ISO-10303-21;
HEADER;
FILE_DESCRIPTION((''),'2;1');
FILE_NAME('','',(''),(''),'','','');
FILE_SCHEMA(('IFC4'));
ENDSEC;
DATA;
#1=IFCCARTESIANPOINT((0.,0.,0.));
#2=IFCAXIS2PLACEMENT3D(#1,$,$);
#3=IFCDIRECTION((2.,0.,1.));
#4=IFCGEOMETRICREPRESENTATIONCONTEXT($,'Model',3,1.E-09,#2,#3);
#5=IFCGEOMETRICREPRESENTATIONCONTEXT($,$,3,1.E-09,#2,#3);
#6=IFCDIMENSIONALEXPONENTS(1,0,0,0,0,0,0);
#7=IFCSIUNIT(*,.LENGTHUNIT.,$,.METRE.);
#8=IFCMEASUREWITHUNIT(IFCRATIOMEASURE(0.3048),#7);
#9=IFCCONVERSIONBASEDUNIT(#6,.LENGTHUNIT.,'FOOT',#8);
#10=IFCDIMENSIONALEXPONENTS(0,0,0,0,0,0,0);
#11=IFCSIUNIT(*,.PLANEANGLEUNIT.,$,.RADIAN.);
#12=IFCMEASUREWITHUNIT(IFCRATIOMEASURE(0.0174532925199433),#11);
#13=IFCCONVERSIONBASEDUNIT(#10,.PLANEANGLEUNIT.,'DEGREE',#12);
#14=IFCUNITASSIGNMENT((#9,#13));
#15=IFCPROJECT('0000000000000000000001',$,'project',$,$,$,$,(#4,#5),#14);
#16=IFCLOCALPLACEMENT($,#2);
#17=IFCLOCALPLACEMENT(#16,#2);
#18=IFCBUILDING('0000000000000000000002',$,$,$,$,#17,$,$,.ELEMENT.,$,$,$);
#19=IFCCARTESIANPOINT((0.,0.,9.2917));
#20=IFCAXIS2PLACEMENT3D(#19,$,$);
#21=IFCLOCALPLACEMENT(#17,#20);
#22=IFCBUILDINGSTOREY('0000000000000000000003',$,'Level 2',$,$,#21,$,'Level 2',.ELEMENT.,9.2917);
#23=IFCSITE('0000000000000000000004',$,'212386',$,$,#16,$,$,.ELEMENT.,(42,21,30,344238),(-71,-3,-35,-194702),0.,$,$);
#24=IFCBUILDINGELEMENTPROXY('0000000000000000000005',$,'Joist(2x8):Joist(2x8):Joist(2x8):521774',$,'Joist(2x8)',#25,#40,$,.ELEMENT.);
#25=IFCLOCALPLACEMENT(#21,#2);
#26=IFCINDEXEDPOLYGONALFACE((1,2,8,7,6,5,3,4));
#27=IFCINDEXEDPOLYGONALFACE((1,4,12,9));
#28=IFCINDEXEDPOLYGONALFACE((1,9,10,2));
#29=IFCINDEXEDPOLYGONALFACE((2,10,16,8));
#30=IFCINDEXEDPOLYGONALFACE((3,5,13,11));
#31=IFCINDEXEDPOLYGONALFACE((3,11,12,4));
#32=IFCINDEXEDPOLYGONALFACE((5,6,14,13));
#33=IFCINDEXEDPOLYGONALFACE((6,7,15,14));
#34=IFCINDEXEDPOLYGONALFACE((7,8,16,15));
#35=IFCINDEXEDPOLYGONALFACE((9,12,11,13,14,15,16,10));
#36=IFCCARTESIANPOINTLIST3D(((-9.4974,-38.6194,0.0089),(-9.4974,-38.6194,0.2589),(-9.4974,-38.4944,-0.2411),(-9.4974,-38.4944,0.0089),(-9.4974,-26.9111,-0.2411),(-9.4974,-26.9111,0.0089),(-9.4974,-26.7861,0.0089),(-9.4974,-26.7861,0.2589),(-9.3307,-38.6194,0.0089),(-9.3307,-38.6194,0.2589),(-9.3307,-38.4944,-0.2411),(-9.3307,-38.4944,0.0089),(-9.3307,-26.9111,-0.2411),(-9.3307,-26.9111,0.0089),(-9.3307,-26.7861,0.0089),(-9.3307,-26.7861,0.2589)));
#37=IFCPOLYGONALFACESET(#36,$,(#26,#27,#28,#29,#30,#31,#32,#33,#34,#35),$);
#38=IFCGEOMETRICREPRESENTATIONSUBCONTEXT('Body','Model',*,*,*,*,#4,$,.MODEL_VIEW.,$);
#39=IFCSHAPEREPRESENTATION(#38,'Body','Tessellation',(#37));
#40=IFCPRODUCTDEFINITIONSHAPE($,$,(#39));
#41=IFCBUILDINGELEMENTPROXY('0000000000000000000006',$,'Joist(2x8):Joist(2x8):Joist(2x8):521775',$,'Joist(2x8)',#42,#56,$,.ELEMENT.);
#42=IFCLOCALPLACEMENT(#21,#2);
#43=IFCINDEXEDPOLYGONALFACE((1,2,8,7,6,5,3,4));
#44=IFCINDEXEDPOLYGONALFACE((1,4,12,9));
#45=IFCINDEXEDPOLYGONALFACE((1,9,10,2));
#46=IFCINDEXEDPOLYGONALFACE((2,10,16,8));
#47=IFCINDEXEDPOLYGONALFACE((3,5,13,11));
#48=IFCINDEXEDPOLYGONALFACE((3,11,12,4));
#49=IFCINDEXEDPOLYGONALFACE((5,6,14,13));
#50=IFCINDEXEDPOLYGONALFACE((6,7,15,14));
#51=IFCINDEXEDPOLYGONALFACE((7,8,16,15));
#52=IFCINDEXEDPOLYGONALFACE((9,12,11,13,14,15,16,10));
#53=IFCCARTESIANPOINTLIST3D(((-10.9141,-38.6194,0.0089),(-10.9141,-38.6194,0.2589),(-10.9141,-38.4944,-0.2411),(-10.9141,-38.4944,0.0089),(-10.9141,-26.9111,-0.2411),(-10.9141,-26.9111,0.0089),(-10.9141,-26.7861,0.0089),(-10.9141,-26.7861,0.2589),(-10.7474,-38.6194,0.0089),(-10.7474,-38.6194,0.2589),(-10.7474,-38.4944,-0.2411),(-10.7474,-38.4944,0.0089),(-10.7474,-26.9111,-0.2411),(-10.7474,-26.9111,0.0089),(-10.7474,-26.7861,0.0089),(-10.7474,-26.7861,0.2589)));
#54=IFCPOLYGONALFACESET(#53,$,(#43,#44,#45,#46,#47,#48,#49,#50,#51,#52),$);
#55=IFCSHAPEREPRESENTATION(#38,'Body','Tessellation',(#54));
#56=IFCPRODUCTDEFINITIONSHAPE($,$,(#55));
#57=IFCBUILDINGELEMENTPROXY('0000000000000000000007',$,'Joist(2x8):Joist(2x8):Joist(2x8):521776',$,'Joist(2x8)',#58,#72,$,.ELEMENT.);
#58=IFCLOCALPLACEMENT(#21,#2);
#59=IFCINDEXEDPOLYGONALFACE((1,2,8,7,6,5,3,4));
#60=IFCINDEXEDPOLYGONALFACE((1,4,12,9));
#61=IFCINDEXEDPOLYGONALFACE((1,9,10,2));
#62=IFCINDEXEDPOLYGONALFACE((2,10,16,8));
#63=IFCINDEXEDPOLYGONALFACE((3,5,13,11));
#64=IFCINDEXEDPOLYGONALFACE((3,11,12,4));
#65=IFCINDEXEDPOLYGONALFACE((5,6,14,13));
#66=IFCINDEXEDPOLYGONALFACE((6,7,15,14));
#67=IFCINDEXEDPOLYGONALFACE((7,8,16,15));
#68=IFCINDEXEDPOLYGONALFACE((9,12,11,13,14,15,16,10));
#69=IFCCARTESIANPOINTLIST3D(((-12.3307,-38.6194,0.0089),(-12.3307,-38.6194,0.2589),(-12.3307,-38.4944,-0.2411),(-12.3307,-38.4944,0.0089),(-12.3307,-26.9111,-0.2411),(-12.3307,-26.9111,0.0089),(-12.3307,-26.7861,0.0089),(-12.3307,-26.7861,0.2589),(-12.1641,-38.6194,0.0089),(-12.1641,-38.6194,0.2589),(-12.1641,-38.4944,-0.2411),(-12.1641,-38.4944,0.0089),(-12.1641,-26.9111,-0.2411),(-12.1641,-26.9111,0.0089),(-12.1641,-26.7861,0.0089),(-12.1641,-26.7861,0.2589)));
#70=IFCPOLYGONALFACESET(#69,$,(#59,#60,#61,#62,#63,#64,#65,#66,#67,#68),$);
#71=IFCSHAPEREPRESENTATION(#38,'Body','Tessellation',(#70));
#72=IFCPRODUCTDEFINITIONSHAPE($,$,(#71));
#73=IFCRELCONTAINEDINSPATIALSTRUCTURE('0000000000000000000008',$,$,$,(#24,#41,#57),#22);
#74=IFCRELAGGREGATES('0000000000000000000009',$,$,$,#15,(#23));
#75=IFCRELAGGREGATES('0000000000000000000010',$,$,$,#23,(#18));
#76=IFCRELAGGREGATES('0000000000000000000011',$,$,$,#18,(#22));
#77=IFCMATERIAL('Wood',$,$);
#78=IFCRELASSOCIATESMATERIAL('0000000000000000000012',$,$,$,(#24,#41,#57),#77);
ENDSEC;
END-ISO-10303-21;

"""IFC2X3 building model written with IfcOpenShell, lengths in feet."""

from ifc_helpers import new_model, entity, si_unit, converted_unit, direction, frame, origin, place, context, subcontext, project, spatial, polyline, outline, extrude, source, transform, mapped, material, element, save


model = new_model("IFC2X3")

# Units and contexts
model_context = context("Model", 3, precision=1e-09, world=origin(), true_north=direction((2.0, 0.0, 1.0)))
context_of_model = context(None, 3, precision=1e-09, world=origin(), true_north=direction((2.0, 0.0, 1.0)))
body_context = subcontext(model_context, "Body", "Model", "MODEL_VIEW")
ifc_project = project(units=[converted_unit("LENGTHUNIT", "FOOT", entity("IfcRatioMeasure", 0.3048), si_unit("LENGTHUNIT", "METRE"), dimensions=[1, 0, 0, 0, 0, 0, 0]), converted_unit("PLANEANGLEUNIT", "DEGREE", entity("IfcRatioMeasure", 0.0174532925199433), si_unit("PLANEANGLEUNIT", "RADIAN"), dimensions=[0, 0, 0, 0, 0, 0, 0])], contexts=[model_context, context_of_model])

# Site, building, storey
site_placement = place(None, origin())
site = spatial("IfcSite", under=ifc_project, at=site_placement, Name="212386", CompositionType="ELEMENT", RefLatitude=(42, 21, 30, 344238), RefLongitude=(-71, -3, -35, -194702), RefElevation=0.0)
building_placement = place(site_placement, origin())
building = spatial("IfcBuilding", under=site, at=building_placement, CompositionType="ELEMENT")
storey_placement = place(building_placement, frame((0.0, 0.0, 9.2917)))
storey = spatial("IfcBuildingStorey", under=building, at=storey_placement, Name="Level 2", LongName="Level 2", CompositionType="ELEMENT", Elevation=9.2917)

# Building element proxies
ifc_material = material(Name="Wood")
shared_shape_1 = source(origin(), body_context, "Body", "SweptSolid", [
    extrude(outline(polyline([(-0.25, -5.9167), (0.0, -5.9167), (0.0, -5.7917), (0.25, -5.7917), (0.25, 5.7917), (0.0, 5.7917), (0.0, 5.9167), (-0.25, 5.9167), (-0.25, -5.9167)])), frame((-9.4974, -32.7027, 9.3006), z_axis=(1.0, 0.0, 0.0), x_axis=(0.0, 0.0, -1.0)), (0.0, 0.0, 1.0), 0.1667),
])
proxy_1_placement = place(storey_placement, frame((0.0, 0.0, -9.2917)))
element("IfcBuildingElementProxy", 1, at=proxy_1_placement, inside=storey, material=ifc_material, Name="Joist(2x8):Joist(2x8):Joist(2x8):521774", ObjectType="Joist(2x8)", CompositionType="ELEMENT", context=body_context, shape_type="MappedRepresentation", body=[
    mapped(shared_shape_1, transform((0.0, 0.0, 0.0), scale=1.0)),
])
shared_shape_2 = source(origin(), body_context, "Body", "SweptSolid", [
    extrude(outline(polyline([(-0.25, -5.9167), (0.0, -5.9167), (0.0, -5.7917), (0.25, -5.7917), (0.25, 5.7917), (0.0, 5.7917), (0.0, 5.9167), (-0.25, 5.9167), (-0.25, -5.9167)])), frame((-10.9141, -32.7027, 9.3006), z_axis=(1.0, 0.0, 0.0), x_axis=(0.0, 0.0, -1.0)), (0.0, 0.0, 1.0), 0.1667),
])
proxy_2_placement = place(storey_placement, frame((0.0, 0.0, -9.2917)))
element("IfcBuildingElementProxy", 2, at=proxy_2_placement, inside=storey, material=ifc_material, Name="Joist(2x8):Joist(2x8):Joist(2x8):521775", ObjectType="Joist(2x8)", CompositionType="ELEMENT", context=body_context, shape_type="MappedRepresentation", body=[
    mapped(shared_shape_2, transform((0.0, 0.0, 0.0), scale=1.0)),
])
shared_shape_3 = source(origin(), body_context, "Body", "SweptSolid", [
    extrude(outline(polyline([(-0.25, -5.9167), (0.0, -5.9167), (0.0, -5.7917), (0.25, -5.7917), (0.25, 5.7917), (0.0, 5.7917), (0.0, 5.9167), (-0.25, 5.9167), (-0.25, -5.9167)])), frame((-12.3307, -32.7027, 9.3006), z_axis=(1.0, 0.0, 0.0), x_axis=(0.0, 0.0, -1.0)), (0.0, 0.0, 1.0), 0.1667),
])
proxy_3_placement = place(storey_placement, frame((0.0, 0.0, -9.2917)))
element("IfcBuildingElementProxy", 3, at=proxy_3_placement, inside=storey, material=ifc_material, Name="Joist(2x8):Joist(2x8):Joist(2x8):521776", ObjectType="Joist(2x8)", CompositionType="ELEMENT", context=body_context, shape_type="MappedRepresentation", body=[
    mapped(shared_shape_3, transform((0.0, 0.0, 0.0), scale=1.0)),
])

save(model, "model.ifc")
